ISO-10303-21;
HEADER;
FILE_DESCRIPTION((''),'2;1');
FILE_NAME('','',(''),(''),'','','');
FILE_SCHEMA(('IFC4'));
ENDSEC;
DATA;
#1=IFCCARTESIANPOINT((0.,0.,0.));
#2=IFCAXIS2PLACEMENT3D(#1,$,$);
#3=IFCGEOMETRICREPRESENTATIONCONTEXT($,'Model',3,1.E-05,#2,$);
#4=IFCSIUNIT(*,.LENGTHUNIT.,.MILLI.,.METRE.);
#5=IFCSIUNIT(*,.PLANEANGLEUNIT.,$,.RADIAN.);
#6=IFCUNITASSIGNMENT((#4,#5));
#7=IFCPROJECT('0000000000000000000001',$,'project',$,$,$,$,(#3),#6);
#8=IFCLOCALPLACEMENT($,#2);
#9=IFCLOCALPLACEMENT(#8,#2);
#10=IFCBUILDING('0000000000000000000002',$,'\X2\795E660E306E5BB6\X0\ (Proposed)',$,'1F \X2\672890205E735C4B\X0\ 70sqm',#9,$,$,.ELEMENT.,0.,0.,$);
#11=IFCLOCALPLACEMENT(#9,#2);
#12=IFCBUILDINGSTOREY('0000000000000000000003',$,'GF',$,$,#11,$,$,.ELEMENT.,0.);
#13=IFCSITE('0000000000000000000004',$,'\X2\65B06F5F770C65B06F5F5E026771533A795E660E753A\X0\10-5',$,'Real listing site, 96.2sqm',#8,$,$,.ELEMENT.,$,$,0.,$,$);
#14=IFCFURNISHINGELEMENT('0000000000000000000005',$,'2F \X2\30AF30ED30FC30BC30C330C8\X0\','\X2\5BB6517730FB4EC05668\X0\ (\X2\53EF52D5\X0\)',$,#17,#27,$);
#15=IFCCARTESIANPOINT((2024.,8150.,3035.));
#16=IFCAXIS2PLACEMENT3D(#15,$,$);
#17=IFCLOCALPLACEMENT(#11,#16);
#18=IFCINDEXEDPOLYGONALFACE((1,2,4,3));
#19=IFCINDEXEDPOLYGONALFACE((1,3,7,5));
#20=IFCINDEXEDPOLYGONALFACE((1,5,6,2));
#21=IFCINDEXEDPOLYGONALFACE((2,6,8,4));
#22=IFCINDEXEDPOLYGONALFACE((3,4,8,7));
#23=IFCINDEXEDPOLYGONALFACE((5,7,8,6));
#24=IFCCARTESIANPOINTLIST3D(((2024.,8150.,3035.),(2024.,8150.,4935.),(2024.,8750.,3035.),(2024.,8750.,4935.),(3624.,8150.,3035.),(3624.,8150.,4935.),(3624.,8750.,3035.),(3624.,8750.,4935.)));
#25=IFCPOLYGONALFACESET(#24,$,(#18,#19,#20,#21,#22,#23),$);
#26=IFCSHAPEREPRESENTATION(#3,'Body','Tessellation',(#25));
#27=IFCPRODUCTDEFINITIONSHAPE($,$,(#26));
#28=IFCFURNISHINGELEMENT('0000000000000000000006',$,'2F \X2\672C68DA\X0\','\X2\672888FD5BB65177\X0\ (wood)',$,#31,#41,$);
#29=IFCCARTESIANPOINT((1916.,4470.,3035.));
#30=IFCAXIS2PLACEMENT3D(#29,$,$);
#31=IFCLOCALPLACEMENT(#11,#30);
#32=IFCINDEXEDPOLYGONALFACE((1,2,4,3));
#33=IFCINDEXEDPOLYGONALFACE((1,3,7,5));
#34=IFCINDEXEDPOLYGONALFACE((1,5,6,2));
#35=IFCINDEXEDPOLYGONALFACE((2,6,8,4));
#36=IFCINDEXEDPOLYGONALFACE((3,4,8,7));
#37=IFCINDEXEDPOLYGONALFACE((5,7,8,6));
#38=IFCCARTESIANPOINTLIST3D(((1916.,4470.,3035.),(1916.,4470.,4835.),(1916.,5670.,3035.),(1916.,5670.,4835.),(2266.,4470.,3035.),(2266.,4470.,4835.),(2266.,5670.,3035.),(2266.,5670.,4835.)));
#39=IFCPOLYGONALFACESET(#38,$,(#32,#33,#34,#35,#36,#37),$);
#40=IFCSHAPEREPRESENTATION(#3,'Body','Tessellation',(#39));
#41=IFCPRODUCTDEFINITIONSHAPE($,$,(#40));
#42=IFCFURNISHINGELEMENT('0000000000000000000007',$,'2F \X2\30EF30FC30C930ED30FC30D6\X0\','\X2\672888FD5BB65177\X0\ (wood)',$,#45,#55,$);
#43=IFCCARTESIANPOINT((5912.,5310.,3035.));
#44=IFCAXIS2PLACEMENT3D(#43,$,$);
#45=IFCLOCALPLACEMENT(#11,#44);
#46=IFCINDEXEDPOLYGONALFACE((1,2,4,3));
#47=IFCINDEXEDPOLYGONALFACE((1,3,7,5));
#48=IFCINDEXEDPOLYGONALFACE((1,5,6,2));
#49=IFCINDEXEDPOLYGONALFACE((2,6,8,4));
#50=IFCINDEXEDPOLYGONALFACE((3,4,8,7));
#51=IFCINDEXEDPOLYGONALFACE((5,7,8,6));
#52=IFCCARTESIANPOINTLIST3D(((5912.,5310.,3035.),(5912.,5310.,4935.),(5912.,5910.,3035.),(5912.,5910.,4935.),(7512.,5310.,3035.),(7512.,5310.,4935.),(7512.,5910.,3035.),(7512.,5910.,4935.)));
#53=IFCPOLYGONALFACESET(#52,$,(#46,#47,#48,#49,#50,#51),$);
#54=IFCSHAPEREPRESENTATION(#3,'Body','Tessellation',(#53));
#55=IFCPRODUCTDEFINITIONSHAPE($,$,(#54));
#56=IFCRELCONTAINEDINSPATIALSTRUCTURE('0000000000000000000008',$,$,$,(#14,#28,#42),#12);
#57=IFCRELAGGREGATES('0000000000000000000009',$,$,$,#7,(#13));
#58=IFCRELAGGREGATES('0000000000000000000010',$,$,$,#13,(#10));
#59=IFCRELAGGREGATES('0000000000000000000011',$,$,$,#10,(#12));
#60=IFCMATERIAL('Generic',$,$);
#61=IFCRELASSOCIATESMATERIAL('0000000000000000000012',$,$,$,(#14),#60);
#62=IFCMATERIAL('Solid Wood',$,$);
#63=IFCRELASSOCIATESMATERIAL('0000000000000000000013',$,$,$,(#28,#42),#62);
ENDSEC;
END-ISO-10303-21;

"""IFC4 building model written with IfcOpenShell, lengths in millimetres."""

from ifc_helpers import new_model, si_unit, frame, frame_2d, origin, place, context, project, spatial, rectangle, extrude, material, element, save


model = new_model("IFC4")

# Units and contexts
model_context = context("Model", 3, precision=1e-05, world=origin())
ifc_project = project(units=[si_unit("LENGTHUNIT", "METRE", prefix="MILLI"), si_unit("PLANEANGLEUNIT", "RADIAN")], contexts=[model_context])

# Site, building, storey
site_placement = place(None, origin())
site = spatial("IfcSite", under=ifc_project, at=site_placement, Name="新潟県新潟市東区神明町10-5", ObjectType="Real listing site, 96.2sqm", CompositionType="ELEMENT", RefElevation=0.0)
building_placement = place(site_placement, origin())
building = spatial("IfcBuilding", under=site, at=building_placement, Name="神明の家 (Proposed)", ObjectType="1F 木造平屋 70sqm", CompositionType="ELEMENT", ElevationOfRefHeight=0.0, ElevationOfTerrain=0.0)
storey_placement = place(building_placement, origin())
storey = spatial("IfcBuildingStorey", under=building, at=storey_placement, Name="GF", CompositionType="ELEMENT", Elevation=0.0)

# Shared definitions
ifc_material_1 = material(Name="Solid Wood")

# Shared definitions
ifc_material_2 = material(Name="Generic")

# Furnishing elements
furnishing_1_placement = place(storey_placement, frame((2024.0, 8150.0, 3035.0)))
element("IfcFurnishingElement", 1, at=furnishing_1_placement, inside=storey, material=ifc_material_2, Name="2F クローゼット", Description="家具・什器 (可動)", context=model_context, shape_type="SweptSolid", body=[
    extrude(rectangle(XDim=1600.0, YDim=600.0, at=frame_2d((800.0, 300.0))), frame((2024.0, 8150.0, 3035.0)), (0.0, 0.0, 1.0), 1900.0),
])
furnishing_2_placement = place(storey_placement, frame((1916.0, 4470.0, 3035.0)))
element("IfcFurnishingElement", 2, at=furnishing_2_placement, inside=storey, material=ifc_material_1, Name="2F 本棚", Description="木製家具 (wood)", context=model_context, shape_type="SweptSolid", body=[
    extrude(rectangle(XDim=350.0, YDim=1200.0, at=frame_2d((175.0, 600.0))), frame((1916.0, 4470.0, 3035.0)), (0.0, 0.0, 1.0), 1800.0),
])
furnishing_3_placement = place(storey_placement, frame((5912.0, 5310.0, 3035.0)))
element("IfcFurnishingElement", 3, at=furnishing_3_placement, inside=storey, material=ifc_material_1, Name="2F ワードローブ", Description="木製家具 (wood)", context=model_context, shape_type="SweptSolid", body=[
    extrude(rectangle(XDim=1600.0, YDim=600.0, at=frame_2d((800.0, 300.0))), frame((5912.0, 5310.0, 3035.0)), (0.0, 0.0, 1.0), 1900.0),
])

save(model, "model.ifc")
